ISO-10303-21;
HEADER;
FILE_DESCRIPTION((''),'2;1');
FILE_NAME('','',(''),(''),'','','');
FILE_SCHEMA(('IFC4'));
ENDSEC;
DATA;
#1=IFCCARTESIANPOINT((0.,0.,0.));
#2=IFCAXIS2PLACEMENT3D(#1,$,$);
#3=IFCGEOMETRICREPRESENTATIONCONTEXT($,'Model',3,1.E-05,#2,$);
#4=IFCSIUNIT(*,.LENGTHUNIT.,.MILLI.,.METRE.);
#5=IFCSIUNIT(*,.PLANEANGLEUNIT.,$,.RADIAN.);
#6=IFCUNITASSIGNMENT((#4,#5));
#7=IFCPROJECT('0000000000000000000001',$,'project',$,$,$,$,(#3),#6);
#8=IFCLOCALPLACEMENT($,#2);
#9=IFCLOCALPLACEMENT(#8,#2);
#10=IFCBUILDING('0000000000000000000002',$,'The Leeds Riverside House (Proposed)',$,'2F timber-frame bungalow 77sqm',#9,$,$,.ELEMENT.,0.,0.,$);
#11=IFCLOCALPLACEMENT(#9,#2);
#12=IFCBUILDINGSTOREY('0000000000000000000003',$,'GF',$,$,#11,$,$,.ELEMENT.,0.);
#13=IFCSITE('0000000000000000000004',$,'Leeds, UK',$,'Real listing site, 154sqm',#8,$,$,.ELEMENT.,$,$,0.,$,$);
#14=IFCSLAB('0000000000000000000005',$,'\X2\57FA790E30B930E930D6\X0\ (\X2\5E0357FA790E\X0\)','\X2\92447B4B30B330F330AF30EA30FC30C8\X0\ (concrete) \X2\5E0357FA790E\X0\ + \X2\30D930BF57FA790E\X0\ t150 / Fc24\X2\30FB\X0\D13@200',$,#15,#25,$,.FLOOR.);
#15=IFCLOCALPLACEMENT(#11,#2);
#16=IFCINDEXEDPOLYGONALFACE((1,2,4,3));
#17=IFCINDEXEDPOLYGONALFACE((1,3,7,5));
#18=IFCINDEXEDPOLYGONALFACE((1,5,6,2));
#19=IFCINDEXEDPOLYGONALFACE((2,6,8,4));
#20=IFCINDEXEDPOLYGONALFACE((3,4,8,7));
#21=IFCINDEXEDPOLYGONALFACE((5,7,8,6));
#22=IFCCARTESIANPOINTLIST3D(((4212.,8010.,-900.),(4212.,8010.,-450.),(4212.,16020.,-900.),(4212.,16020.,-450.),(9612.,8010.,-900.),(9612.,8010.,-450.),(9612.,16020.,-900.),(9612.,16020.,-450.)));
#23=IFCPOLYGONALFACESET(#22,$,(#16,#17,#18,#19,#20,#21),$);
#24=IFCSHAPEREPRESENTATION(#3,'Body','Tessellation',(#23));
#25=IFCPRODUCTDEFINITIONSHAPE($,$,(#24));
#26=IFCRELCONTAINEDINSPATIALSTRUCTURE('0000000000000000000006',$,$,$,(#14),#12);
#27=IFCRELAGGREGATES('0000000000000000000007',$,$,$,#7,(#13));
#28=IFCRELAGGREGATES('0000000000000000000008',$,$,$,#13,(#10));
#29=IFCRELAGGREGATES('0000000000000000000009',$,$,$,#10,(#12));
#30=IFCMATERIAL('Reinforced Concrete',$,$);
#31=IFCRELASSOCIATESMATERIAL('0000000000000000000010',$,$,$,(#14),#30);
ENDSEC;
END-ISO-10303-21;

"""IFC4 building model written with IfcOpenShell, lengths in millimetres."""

from ifc_helpers import new_model, si_unit, frame, frame_2d, origin, place, context, project, spatial, rectangle, extrude, material, element, save


model = new_model("IFC4")

# Units and contexts
model_context = context("Model", 3, precision=1e-05, world=origin())
ifc_project = project(units=[si_unit("LENGTHUNIT", "METRE", prefix="MILLI"), si_unit("PLANEANGLEUNIT", "RADIAN")], contexts=[model_context])

# Site, building, storey
site_placement = place(None, origin())
site = spatial("IfcSite", under=ifc_project, at=site_placement, Name="Leeds, UK", ObjectType="Real listing site, 154sqm", CompositionType="ELEMENT", RefElevation=0.0)
building_placement = place(site_placement, origin())
building = spatial("IfcBuilding", under=site, at=building_placement, Name="The Leeds Riverside House (Proposed)", ObjectType="2F timber-frame bungalow 77sqm", CompositionType="ELEMENT", ElevationOfRefHeight=0.0, ElevationOfTerrain=0.0)
storey_placement = place(building_placement, origin())
storey = spatial("IfcBuildingStorey", under=building, at=storey_placement, Name="GF", CompositionType="ELEMENT", Elevation=0.0)

# Slab
ifc_material_1 = material(Name="Reinforced Concrete")
slab_1_placement = place(storey_placement, frame((2106.0, 4005.0, -450.0)))
element("IfcSlab", 1, at=slab_1_placement, inside=storey, material=ifc_material_1, Name="基礎スラブ (布基礎)", Description="鉄筋コンクリート (concrete) 布基礎 + ベタ基礎 t150 / Fc24・D13@200", PredefinedType="FLOOR", context=model_context, shape_type="SweptSolid", body=[
    extrude(rectangle(XDim=5400.0, YDim=8010.0, at=frame_2d((2700.0, 4005.0))), frame((2106.0, 4005.0, -450.0)), (0.0, 0.0, 1.0), 450.0),
])

save(model, "model.ifc")
